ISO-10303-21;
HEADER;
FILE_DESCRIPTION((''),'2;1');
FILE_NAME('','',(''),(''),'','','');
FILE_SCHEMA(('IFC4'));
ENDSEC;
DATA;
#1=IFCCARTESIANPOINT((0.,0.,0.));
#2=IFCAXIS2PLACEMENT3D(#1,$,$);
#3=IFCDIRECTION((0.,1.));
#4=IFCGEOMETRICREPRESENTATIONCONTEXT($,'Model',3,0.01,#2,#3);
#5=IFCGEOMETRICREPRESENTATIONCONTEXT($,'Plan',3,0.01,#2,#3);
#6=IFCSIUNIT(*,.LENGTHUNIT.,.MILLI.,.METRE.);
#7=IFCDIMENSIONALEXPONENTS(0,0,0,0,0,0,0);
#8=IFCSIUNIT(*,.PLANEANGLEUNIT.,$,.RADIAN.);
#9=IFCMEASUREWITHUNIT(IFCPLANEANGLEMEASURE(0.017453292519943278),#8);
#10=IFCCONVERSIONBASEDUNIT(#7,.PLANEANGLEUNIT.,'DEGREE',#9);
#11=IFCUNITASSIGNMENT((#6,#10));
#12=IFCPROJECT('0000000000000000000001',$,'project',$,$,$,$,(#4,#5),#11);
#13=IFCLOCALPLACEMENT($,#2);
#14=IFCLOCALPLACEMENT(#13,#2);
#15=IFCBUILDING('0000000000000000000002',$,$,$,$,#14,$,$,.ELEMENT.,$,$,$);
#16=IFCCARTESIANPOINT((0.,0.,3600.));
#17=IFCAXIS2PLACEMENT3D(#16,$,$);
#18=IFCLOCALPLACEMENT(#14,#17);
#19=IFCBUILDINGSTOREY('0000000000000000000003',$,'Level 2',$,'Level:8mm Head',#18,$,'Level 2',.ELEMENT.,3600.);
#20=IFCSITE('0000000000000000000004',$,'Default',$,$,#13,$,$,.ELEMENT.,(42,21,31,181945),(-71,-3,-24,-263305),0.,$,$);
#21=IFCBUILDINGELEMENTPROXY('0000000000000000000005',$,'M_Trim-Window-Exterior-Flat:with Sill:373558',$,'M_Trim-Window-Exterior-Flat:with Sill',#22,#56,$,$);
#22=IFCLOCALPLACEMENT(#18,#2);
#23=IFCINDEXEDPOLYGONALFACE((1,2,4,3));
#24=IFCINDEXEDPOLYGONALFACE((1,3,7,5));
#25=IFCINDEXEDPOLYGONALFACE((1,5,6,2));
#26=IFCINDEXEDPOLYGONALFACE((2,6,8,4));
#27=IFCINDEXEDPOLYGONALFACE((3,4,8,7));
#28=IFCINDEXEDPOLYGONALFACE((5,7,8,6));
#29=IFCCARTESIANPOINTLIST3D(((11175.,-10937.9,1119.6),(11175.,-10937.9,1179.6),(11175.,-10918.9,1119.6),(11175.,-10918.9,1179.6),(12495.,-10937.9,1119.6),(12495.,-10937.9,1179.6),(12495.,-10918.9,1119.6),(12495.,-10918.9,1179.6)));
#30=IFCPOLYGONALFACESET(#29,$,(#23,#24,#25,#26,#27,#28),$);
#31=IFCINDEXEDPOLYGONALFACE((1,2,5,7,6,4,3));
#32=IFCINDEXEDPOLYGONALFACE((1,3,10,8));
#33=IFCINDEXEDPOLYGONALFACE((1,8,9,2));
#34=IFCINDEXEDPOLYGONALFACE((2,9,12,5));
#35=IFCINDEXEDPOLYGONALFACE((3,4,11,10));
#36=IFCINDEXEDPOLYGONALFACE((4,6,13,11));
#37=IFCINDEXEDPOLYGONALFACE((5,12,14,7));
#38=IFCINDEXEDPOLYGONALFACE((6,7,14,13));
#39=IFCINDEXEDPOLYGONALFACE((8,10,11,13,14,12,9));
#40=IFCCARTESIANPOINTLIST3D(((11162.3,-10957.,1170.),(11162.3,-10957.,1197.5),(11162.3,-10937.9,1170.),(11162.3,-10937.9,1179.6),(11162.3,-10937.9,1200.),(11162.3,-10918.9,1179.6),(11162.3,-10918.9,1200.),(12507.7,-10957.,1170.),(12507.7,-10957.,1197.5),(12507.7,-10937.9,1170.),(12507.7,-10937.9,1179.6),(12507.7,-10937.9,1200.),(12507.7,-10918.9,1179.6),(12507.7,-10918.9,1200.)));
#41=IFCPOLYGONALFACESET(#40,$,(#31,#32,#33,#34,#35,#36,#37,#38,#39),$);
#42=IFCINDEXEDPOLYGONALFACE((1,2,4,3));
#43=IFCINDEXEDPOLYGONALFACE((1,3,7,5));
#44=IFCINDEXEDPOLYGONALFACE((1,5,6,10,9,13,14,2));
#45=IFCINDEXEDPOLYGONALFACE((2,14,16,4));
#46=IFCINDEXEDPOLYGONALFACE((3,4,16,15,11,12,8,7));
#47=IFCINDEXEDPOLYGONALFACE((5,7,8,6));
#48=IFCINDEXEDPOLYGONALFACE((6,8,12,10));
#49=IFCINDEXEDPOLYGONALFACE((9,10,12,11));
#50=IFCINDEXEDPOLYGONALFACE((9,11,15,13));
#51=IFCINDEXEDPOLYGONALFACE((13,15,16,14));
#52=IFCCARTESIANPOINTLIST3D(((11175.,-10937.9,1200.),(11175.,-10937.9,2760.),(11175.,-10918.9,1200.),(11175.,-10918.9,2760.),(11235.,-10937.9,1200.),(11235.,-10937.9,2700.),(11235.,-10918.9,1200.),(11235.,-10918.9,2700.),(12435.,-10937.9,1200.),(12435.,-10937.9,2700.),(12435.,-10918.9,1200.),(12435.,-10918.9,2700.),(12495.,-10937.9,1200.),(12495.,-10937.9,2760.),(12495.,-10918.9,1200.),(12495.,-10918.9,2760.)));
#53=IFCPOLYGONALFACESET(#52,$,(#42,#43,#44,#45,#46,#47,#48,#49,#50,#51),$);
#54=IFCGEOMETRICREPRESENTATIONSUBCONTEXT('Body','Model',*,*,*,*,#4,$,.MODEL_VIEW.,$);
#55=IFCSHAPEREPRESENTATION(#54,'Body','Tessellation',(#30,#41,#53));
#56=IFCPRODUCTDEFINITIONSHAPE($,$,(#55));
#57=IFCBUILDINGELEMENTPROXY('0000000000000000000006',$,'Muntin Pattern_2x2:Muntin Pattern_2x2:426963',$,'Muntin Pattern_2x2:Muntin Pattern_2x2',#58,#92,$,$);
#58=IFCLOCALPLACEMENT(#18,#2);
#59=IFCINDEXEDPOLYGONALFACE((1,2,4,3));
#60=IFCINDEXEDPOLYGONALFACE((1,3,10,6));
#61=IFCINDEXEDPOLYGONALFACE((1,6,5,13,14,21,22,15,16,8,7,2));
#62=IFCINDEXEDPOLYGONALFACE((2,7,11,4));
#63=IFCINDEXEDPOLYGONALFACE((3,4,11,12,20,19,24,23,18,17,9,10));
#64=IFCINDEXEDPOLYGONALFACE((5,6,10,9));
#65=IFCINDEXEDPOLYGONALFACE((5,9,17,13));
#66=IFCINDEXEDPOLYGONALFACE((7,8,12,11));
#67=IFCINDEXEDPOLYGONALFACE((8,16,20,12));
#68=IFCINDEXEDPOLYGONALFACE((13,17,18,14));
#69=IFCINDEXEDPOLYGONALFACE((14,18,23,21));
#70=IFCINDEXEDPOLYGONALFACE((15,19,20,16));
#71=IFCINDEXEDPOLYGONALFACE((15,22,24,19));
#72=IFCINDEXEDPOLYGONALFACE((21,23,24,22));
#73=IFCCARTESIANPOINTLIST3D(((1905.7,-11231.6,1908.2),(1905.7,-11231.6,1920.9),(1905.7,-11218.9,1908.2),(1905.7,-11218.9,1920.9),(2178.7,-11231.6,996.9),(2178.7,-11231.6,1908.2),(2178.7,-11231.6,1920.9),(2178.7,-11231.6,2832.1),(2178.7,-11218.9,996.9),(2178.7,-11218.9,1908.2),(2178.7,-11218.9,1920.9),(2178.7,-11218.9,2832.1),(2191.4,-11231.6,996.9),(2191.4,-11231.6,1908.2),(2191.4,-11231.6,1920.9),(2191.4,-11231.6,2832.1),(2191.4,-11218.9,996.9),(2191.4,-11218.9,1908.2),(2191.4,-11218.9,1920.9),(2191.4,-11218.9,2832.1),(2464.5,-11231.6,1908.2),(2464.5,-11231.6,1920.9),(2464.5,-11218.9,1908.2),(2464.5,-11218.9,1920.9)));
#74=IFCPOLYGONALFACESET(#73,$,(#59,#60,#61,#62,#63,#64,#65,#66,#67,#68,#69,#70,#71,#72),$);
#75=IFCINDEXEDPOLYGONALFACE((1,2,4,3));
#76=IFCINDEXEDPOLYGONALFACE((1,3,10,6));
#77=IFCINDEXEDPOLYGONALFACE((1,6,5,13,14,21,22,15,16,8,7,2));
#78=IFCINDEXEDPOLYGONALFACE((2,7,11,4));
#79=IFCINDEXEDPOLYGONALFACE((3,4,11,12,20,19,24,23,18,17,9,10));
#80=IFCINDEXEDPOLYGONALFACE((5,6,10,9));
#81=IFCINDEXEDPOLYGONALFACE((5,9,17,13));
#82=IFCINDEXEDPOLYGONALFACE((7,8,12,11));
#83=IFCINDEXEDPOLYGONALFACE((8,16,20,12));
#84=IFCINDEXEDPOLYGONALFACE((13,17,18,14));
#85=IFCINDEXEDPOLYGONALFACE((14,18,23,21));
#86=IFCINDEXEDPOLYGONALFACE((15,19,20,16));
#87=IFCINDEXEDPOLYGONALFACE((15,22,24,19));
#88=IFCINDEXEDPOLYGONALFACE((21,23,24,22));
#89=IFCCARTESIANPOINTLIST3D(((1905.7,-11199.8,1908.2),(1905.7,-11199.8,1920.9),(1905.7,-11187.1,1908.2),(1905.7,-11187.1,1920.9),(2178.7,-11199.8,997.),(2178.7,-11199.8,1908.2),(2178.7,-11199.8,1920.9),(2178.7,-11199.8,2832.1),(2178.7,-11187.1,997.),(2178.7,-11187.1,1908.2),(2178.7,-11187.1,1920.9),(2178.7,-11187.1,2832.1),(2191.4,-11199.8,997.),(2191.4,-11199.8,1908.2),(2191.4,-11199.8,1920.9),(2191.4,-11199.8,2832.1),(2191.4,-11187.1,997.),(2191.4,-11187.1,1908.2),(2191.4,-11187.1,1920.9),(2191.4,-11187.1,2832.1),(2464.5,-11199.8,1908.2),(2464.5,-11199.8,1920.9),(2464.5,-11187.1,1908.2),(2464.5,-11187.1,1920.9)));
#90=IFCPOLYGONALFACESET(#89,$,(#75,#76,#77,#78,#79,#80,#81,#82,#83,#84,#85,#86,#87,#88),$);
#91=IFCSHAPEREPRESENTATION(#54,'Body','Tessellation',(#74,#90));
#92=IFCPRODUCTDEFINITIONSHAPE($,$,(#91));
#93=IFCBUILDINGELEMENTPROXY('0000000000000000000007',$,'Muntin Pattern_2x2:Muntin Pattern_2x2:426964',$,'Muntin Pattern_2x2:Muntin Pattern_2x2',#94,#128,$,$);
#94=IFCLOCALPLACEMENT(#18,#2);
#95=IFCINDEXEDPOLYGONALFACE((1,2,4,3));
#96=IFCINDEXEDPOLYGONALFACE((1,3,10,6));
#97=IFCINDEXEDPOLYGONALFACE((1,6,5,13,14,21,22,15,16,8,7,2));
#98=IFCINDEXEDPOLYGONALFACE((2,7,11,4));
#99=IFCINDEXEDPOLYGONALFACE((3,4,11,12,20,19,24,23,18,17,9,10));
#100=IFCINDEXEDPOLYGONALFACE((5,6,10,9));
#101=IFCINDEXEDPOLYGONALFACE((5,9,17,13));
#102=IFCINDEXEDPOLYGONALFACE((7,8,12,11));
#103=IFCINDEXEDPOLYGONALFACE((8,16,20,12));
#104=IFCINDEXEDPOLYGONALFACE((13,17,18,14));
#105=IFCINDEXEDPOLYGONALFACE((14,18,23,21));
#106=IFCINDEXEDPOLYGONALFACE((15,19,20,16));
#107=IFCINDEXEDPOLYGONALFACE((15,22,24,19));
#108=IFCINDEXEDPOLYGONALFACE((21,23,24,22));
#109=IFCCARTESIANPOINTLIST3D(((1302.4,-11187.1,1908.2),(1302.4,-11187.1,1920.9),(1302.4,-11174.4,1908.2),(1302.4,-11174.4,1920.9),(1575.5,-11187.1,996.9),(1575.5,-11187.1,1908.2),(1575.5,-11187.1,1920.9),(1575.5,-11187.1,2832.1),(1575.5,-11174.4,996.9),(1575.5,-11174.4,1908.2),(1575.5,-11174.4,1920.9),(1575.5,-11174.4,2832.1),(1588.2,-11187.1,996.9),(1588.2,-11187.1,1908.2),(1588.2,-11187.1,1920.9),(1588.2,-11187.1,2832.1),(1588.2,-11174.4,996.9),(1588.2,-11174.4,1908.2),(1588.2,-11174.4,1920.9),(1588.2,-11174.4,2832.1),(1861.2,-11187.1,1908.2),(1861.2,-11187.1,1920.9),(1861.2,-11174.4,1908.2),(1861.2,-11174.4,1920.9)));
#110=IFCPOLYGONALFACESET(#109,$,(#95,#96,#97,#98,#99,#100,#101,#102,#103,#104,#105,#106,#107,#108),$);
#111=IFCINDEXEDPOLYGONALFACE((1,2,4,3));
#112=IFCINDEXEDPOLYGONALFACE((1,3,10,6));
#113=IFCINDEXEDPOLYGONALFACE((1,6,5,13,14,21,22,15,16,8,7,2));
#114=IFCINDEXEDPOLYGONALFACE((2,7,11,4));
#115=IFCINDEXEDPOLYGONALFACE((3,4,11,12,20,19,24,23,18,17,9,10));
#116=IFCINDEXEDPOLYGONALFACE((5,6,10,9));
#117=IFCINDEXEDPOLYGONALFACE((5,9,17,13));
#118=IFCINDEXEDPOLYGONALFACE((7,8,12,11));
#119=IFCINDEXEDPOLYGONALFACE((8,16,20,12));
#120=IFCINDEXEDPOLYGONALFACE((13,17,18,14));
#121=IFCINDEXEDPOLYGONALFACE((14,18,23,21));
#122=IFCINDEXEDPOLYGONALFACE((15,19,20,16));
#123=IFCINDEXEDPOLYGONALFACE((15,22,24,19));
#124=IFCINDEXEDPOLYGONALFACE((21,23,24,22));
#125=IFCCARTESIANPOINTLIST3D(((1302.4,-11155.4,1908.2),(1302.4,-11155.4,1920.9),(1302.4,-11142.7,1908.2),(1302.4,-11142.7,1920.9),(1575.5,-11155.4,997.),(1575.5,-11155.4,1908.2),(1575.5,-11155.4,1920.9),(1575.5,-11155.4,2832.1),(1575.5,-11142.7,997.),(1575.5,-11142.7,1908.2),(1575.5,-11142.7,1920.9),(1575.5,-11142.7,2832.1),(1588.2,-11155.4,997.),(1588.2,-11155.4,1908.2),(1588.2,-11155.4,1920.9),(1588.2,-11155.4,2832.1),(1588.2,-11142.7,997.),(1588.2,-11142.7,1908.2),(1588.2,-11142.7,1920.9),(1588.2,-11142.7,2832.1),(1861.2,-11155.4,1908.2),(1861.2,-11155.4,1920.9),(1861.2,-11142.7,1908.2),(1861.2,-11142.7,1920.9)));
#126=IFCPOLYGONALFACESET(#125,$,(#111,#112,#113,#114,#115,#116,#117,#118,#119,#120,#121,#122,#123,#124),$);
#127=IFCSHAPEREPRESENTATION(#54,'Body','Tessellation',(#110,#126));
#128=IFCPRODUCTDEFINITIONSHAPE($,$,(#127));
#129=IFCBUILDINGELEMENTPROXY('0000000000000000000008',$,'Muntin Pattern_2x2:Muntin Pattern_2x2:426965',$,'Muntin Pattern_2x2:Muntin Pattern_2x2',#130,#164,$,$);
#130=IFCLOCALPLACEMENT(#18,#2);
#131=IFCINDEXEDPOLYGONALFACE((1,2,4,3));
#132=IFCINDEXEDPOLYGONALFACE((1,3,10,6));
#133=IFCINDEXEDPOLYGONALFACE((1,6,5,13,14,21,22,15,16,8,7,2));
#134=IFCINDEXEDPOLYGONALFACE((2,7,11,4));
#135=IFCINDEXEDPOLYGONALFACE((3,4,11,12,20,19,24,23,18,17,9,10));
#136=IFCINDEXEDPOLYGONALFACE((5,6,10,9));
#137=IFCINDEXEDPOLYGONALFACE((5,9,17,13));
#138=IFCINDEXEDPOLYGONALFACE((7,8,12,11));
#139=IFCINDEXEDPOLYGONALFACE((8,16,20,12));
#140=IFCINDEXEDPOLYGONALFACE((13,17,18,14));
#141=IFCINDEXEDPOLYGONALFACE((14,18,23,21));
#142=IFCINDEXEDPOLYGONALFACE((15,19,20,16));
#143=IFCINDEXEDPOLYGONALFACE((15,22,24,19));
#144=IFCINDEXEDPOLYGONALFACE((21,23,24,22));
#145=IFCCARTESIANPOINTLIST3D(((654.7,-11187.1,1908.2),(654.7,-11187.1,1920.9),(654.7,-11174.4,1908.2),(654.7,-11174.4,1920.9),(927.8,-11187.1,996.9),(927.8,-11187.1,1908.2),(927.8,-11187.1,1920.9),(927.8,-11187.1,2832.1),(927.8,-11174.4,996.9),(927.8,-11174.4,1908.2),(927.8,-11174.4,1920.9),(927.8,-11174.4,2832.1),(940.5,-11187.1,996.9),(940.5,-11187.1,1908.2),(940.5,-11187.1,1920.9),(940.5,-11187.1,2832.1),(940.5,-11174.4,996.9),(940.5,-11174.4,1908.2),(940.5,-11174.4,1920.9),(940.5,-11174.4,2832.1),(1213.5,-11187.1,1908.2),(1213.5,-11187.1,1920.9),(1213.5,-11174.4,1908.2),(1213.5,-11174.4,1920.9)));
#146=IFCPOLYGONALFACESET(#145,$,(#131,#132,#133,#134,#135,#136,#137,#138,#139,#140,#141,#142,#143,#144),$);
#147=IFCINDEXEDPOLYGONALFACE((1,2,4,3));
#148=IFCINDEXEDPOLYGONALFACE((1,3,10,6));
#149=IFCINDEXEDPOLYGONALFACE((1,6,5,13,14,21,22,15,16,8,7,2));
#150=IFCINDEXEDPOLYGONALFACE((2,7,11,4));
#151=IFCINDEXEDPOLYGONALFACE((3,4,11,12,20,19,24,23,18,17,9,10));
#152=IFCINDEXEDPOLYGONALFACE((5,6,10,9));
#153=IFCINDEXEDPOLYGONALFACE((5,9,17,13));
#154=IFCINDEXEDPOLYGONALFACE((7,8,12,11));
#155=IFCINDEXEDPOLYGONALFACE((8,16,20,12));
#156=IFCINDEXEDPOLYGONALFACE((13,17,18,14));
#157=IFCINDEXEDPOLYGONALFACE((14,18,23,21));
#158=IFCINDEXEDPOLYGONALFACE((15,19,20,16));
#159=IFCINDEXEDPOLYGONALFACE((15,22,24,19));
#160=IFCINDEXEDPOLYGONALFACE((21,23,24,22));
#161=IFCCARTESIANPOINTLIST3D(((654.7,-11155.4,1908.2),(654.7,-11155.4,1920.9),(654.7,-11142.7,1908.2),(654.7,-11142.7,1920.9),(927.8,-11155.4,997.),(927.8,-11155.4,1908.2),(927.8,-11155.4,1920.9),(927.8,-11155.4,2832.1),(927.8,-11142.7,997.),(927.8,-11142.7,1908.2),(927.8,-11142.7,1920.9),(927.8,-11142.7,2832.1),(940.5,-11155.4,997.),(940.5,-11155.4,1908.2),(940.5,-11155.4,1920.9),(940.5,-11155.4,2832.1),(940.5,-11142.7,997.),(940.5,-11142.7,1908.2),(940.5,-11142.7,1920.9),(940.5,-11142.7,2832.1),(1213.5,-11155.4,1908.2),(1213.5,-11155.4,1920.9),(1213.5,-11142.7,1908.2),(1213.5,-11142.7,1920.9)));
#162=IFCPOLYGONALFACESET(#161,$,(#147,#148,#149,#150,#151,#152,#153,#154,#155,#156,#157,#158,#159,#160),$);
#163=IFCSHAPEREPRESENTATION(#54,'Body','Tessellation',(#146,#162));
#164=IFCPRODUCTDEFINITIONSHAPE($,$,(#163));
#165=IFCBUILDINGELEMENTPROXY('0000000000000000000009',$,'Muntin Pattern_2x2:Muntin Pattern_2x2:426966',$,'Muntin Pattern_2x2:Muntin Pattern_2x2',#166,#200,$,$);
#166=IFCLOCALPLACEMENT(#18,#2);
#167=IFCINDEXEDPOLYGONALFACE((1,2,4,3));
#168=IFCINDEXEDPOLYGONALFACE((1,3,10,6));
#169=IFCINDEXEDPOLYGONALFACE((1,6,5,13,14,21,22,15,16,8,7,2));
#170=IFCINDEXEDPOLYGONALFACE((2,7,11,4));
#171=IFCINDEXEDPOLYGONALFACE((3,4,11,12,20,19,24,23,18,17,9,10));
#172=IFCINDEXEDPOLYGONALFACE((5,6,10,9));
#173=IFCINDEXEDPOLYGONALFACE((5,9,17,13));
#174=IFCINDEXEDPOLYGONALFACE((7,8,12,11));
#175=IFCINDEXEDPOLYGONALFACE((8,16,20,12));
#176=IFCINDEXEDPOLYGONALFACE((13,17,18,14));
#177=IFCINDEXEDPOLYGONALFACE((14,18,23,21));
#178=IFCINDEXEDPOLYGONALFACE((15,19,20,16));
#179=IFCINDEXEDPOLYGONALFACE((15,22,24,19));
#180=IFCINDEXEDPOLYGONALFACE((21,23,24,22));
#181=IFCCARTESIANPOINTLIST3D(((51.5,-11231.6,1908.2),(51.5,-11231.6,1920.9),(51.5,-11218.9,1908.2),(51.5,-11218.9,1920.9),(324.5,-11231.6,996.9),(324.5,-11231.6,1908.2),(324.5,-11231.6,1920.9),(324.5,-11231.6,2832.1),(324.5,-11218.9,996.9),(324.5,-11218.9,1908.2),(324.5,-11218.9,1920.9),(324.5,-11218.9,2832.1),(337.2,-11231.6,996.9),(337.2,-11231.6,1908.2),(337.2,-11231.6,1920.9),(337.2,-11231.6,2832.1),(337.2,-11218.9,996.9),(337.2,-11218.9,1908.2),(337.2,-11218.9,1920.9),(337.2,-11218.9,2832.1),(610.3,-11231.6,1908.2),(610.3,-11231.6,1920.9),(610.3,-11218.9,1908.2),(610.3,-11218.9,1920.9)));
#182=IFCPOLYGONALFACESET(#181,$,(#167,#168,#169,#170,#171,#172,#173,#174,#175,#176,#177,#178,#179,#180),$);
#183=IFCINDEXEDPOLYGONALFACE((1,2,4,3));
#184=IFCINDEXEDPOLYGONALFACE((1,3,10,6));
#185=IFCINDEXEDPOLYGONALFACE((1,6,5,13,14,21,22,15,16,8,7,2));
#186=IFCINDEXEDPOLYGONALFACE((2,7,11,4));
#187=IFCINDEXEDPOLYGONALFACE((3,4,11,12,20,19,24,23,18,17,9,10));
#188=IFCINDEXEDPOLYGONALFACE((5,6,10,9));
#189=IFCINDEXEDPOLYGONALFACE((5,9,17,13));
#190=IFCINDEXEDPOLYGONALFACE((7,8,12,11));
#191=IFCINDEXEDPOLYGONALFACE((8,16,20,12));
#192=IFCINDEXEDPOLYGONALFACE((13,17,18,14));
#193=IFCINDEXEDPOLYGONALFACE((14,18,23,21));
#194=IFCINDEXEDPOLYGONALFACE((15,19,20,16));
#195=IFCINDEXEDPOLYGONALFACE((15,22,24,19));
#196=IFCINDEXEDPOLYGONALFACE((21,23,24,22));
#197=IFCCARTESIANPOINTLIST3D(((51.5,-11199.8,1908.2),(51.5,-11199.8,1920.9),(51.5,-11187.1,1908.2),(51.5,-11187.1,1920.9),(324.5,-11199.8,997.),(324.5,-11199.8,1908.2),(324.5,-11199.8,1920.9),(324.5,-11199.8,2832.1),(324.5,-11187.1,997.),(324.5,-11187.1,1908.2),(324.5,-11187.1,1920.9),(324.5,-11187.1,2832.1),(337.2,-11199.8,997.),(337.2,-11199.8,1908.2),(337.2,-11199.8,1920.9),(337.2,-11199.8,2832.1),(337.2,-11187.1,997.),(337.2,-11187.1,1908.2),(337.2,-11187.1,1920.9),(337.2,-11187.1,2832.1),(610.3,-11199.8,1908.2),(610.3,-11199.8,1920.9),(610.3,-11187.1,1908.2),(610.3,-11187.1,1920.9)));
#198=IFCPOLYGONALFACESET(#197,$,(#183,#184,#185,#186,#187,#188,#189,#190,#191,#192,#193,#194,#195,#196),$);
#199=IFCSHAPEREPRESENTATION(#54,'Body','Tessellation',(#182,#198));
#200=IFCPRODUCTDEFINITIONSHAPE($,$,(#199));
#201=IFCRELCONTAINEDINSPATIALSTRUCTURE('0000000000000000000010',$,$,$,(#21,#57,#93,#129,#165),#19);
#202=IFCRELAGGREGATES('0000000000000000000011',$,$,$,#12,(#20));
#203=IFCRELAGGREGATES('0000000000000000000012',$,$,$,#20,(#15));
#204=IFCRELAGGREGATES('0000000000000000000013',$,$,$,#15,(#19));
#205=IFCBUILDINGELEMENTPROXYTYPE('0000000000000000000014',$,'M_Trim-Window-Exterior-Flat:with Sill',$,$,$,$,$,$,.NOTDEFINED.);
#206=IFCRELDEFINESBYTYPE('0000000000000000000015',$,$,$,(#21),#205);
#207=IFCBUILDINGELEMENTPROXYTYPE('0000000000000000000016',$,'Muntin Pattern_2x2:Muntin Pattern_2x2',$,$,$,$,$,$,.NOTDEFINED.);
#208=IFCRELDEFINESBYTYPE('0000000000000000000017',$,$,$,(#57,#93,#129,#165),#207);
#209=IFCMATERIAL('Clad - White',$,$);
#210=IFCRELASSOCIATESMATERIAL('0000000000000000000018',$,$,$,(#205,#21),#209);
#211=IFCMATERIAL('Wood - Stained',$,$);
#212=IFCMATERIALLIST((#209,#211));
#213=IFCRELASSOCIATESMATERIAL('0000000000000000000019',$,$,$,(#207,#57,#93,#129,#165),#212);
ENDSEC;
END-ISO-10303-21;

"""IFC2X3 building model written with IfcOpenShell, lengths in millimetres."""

from ifc_helpers import new_model, entity, si_unit, converted_unit, direction, frame, frame_2d, origin, place, context, subcontext, project, spatial, polyline, rectangle, outline, extrude, source, transform, mapped, material, material_list, type_object, type_shapes, element, save


model = new_model("IFC2X3")

# Units and contexts
model_context = context("Model", 3, precision=0.01, world=origin(), true_north=direction((0.0, 1.0)))
plan_context = context("Plan", 3, precision=0.01, world=origin(), true_north=direction((0.0, 1.0)))
body_context = subcontext(model_context, "Body", "Model", "MODEL_VIEW")
ifc_project = project(units=[si_unit("LENGTHUNIT", "METRE", prefix="MILLI"), converted_unit("PLANEANGLEUNIT", "DEGREE", entity("IfcPlaneAngleMeasure", 0.017453292519943278), si_unit("PLANEANGLEUNIT", "RADIAN"), dimensions=[0, 0, 0, 0, 0, 0, 0])], contexts=[model_context, plan_context])

# Site, building, storey
site_placement = place(None, origin())
site = spatial("IfcSite", under=ifc_project, at=site_placement, Name="Default", CompositionType="ELEMENT", RefLatitude=(42, 21, 31, 181945), RefLongitude=(-71, -3, -24, -263305), RefElevation=0.0)
building_placement = place(site_placement, origin())
building = spatial("IfcBuilding", under=site, at=building_placement, CompositionType="ELEMENT")
storey_placement = place(building_placement, frame((0.0, 0.0, 3600.0)))
storey = spatial("IfcBuildingStorey", under=building, at=storey_placement, Name="Level 2", ObjectType="Level:8mm Head", LongName="Level 2", CompositionType="ELEMENT", Elevation=3600.0)

# Building element proxies
ifc_material_1 = material(Name="Clad - White")
ifc_material_2 = material(Name="Wood - Stained")
ifc_material_list = material_list([ifc_material_1, ifc_material_2])
building_element_proxy_type_1 = type_object("IfcBuildingElementProxyType", Name="M_Trim-Window-Exterior-Flat:with Sill", PredefinedType="NOTDEFINED", material=ifc_material_1)
shared_shape_1 = source(origin(), body_context, "Body", "SweptSolid", [
    extrude(rectangle(XDim=1320.0, YDim=60.0, at=frame_2d((0.0, 0.0), x_axis=(1.0, 0.0))), frame((0.0, -1550.4, 0.0), z_axis=(0.0, 0.0, 1.0), x_axis=(-1.0, 0.0, 0.0)), (0.0, 0.0, 1.0), 19.0),
    extrude(outline(polyline([(-19.0, -15.2), (0.0, -15.2), (0.0, -5.7), (19.0, -5.7), (19.0, 14.8), (0.0, 14.8), (-19.0, 12.3), (-19.0, -15.2)])), frame((-672.7, -1514.8, 19.0), z_axis=(1.0, 0.0, 0.0), x_axis=(0.0, 0.0, -1.0)), (0.0, 0.0, 1.0), 1345.4),
    extrude(outline(polyline([(-795.0, -660.0), (765.0, -660.0), (765.0, -600.0), (-735.0, -600.0), (-735.0, 600.0), (765.0, 600.0), (765.0, 660.0), (-795.0, 660.0), (-795.0, -660.0)])), frame((0.0, -735.0, 0.0), z_axis=(0.0, 0.0, 1.0), x_axis=(0.0, -1.0, 0.0)), (0.0, 0.0, 1.0), 19.0),
])
type_shapes(building_element_proxy_type_1, [shared_shape_1])
for number, where, z_axis, x_axis, name in (
    (1, (11835.0, -10918.9, 2700.0), (0.0, -1.0, 0.0), (1.0, 0.0, 0.0), "M_Trim-Window-Exterior-Flat:with Sill:373558"),
):
    element("IfcBuildingElementProxy", number, at=place(storey_placement, frame(where, z_axis=z_axis, x_axis=x_axis)), inside=storey, type_object=building_element_proxy_type_1, material=ifc_material_1, Name=name, ObjectType="M_Trim-Window-Exterior-Flat:with Sill", context=body_context, shape_type="MappedRepresentation", body=[
        mapped(shared_shape_1, transform((0.0, 0.0, 0.0), scale=1.0)),
    ])
building_element_proxy_type_2 = type_object("IfcBuildingElementProxyType", Name="Muntin Pattern_2x2:Muntin Pattern_2x2", PredefinedType="NOTDEFINED", material=ifc_material_list)
shared_shape_2 = source(origin(), body_context, "Body", "SweptSolid", [
    extrude(outline(polyline([(6.4, -6.4), (917.6, -6.4), (917.6, 6.3), (6.4, 6.3), (6.4, 279.4), (-6.3, 279.4), (-6.3, 6.3), (-917.6, 6.3), (-917.6, -6.4), (-6.3, -6.4), (-6.3, -279.4), (6.4, -279.4), (6.4, -6.4)])), frame((0.0, 9.5, 917.6), z_axis=(0.0, 1.0, 0.0), x_axis=(0.0, 0.0, 1.0)), (0.0, 0.0, 1.0), 12.7),
    extrude(outline(polyline([(6.4, -6.4), (917.6, -6.4), (917.6, 6.3), (6.4, 6.3), (6.4, 279.4), (-6.3, 279.4), (-6.3, 6.3), (-917.6, 6.3), (-917.6, -6.4), (-6.3, -6.4), (-6.3, -279.4), (6.4, -279.4), (6.4, -6.4)])), frame((0.0, -22.2, 917.6), z_axis=(0.0, 1.0, 0.0), x_axis=(0.0, 0.0, 1.0)), (0.0, 0.0, 1.0), 12.7),
])
type_shapes(building_element_proxy_type_2, [shared_shape_2])
for number, where, z_axis, x_axis, name in (
    (2, (2185.1, -11209.4, 997.0), (0.0, 0.0, 1.0), (-1.0, 0.0, 0.0), "Muntin Pattern_2x2:Muntin Pattern_2x2:426963"),
    (3, (1581.8, -11164.9, 997.0), (0.0, 0.0, 1.0), (-1.0, 0.0, 0.0), "Muntin Pattern_2x2:Muntin Pattern_2x2:426964"),
    (4, (934.1, -11164.9, 997.0), (0.0, 0.0, 1.0), (-1.0, 0.0, 0.0), "Muntin Pattern_2x2:Muntin Pattern_2x2:426965"),
    (5, (330.9, -11209.4, 997.0), (0.0, 0.0, 1.0), (-1.0, 0.0, 0.0), "Muntin Pattern_2x2:Muntin Pattern_2x2:426966"),
):
    element("IfcBuildingElementProxy", number, at=place(storey_placement, frame(where, z_axis=z_axis, x_axis=x_axis)), inside=storey, type_object=building_element_proxy_type_2, material=ifc_material_list, Name=name, ObjectType="Muntin Pattern_2x2:Muntin Pattern_2x2", context=body_context, shape_type="MappedRepresentation", body=[
        mapped(shared_shape_2, transform((0.0, 0.0, 0.0), scale=1.0)),
    ])

save(model, "model.ifc")
